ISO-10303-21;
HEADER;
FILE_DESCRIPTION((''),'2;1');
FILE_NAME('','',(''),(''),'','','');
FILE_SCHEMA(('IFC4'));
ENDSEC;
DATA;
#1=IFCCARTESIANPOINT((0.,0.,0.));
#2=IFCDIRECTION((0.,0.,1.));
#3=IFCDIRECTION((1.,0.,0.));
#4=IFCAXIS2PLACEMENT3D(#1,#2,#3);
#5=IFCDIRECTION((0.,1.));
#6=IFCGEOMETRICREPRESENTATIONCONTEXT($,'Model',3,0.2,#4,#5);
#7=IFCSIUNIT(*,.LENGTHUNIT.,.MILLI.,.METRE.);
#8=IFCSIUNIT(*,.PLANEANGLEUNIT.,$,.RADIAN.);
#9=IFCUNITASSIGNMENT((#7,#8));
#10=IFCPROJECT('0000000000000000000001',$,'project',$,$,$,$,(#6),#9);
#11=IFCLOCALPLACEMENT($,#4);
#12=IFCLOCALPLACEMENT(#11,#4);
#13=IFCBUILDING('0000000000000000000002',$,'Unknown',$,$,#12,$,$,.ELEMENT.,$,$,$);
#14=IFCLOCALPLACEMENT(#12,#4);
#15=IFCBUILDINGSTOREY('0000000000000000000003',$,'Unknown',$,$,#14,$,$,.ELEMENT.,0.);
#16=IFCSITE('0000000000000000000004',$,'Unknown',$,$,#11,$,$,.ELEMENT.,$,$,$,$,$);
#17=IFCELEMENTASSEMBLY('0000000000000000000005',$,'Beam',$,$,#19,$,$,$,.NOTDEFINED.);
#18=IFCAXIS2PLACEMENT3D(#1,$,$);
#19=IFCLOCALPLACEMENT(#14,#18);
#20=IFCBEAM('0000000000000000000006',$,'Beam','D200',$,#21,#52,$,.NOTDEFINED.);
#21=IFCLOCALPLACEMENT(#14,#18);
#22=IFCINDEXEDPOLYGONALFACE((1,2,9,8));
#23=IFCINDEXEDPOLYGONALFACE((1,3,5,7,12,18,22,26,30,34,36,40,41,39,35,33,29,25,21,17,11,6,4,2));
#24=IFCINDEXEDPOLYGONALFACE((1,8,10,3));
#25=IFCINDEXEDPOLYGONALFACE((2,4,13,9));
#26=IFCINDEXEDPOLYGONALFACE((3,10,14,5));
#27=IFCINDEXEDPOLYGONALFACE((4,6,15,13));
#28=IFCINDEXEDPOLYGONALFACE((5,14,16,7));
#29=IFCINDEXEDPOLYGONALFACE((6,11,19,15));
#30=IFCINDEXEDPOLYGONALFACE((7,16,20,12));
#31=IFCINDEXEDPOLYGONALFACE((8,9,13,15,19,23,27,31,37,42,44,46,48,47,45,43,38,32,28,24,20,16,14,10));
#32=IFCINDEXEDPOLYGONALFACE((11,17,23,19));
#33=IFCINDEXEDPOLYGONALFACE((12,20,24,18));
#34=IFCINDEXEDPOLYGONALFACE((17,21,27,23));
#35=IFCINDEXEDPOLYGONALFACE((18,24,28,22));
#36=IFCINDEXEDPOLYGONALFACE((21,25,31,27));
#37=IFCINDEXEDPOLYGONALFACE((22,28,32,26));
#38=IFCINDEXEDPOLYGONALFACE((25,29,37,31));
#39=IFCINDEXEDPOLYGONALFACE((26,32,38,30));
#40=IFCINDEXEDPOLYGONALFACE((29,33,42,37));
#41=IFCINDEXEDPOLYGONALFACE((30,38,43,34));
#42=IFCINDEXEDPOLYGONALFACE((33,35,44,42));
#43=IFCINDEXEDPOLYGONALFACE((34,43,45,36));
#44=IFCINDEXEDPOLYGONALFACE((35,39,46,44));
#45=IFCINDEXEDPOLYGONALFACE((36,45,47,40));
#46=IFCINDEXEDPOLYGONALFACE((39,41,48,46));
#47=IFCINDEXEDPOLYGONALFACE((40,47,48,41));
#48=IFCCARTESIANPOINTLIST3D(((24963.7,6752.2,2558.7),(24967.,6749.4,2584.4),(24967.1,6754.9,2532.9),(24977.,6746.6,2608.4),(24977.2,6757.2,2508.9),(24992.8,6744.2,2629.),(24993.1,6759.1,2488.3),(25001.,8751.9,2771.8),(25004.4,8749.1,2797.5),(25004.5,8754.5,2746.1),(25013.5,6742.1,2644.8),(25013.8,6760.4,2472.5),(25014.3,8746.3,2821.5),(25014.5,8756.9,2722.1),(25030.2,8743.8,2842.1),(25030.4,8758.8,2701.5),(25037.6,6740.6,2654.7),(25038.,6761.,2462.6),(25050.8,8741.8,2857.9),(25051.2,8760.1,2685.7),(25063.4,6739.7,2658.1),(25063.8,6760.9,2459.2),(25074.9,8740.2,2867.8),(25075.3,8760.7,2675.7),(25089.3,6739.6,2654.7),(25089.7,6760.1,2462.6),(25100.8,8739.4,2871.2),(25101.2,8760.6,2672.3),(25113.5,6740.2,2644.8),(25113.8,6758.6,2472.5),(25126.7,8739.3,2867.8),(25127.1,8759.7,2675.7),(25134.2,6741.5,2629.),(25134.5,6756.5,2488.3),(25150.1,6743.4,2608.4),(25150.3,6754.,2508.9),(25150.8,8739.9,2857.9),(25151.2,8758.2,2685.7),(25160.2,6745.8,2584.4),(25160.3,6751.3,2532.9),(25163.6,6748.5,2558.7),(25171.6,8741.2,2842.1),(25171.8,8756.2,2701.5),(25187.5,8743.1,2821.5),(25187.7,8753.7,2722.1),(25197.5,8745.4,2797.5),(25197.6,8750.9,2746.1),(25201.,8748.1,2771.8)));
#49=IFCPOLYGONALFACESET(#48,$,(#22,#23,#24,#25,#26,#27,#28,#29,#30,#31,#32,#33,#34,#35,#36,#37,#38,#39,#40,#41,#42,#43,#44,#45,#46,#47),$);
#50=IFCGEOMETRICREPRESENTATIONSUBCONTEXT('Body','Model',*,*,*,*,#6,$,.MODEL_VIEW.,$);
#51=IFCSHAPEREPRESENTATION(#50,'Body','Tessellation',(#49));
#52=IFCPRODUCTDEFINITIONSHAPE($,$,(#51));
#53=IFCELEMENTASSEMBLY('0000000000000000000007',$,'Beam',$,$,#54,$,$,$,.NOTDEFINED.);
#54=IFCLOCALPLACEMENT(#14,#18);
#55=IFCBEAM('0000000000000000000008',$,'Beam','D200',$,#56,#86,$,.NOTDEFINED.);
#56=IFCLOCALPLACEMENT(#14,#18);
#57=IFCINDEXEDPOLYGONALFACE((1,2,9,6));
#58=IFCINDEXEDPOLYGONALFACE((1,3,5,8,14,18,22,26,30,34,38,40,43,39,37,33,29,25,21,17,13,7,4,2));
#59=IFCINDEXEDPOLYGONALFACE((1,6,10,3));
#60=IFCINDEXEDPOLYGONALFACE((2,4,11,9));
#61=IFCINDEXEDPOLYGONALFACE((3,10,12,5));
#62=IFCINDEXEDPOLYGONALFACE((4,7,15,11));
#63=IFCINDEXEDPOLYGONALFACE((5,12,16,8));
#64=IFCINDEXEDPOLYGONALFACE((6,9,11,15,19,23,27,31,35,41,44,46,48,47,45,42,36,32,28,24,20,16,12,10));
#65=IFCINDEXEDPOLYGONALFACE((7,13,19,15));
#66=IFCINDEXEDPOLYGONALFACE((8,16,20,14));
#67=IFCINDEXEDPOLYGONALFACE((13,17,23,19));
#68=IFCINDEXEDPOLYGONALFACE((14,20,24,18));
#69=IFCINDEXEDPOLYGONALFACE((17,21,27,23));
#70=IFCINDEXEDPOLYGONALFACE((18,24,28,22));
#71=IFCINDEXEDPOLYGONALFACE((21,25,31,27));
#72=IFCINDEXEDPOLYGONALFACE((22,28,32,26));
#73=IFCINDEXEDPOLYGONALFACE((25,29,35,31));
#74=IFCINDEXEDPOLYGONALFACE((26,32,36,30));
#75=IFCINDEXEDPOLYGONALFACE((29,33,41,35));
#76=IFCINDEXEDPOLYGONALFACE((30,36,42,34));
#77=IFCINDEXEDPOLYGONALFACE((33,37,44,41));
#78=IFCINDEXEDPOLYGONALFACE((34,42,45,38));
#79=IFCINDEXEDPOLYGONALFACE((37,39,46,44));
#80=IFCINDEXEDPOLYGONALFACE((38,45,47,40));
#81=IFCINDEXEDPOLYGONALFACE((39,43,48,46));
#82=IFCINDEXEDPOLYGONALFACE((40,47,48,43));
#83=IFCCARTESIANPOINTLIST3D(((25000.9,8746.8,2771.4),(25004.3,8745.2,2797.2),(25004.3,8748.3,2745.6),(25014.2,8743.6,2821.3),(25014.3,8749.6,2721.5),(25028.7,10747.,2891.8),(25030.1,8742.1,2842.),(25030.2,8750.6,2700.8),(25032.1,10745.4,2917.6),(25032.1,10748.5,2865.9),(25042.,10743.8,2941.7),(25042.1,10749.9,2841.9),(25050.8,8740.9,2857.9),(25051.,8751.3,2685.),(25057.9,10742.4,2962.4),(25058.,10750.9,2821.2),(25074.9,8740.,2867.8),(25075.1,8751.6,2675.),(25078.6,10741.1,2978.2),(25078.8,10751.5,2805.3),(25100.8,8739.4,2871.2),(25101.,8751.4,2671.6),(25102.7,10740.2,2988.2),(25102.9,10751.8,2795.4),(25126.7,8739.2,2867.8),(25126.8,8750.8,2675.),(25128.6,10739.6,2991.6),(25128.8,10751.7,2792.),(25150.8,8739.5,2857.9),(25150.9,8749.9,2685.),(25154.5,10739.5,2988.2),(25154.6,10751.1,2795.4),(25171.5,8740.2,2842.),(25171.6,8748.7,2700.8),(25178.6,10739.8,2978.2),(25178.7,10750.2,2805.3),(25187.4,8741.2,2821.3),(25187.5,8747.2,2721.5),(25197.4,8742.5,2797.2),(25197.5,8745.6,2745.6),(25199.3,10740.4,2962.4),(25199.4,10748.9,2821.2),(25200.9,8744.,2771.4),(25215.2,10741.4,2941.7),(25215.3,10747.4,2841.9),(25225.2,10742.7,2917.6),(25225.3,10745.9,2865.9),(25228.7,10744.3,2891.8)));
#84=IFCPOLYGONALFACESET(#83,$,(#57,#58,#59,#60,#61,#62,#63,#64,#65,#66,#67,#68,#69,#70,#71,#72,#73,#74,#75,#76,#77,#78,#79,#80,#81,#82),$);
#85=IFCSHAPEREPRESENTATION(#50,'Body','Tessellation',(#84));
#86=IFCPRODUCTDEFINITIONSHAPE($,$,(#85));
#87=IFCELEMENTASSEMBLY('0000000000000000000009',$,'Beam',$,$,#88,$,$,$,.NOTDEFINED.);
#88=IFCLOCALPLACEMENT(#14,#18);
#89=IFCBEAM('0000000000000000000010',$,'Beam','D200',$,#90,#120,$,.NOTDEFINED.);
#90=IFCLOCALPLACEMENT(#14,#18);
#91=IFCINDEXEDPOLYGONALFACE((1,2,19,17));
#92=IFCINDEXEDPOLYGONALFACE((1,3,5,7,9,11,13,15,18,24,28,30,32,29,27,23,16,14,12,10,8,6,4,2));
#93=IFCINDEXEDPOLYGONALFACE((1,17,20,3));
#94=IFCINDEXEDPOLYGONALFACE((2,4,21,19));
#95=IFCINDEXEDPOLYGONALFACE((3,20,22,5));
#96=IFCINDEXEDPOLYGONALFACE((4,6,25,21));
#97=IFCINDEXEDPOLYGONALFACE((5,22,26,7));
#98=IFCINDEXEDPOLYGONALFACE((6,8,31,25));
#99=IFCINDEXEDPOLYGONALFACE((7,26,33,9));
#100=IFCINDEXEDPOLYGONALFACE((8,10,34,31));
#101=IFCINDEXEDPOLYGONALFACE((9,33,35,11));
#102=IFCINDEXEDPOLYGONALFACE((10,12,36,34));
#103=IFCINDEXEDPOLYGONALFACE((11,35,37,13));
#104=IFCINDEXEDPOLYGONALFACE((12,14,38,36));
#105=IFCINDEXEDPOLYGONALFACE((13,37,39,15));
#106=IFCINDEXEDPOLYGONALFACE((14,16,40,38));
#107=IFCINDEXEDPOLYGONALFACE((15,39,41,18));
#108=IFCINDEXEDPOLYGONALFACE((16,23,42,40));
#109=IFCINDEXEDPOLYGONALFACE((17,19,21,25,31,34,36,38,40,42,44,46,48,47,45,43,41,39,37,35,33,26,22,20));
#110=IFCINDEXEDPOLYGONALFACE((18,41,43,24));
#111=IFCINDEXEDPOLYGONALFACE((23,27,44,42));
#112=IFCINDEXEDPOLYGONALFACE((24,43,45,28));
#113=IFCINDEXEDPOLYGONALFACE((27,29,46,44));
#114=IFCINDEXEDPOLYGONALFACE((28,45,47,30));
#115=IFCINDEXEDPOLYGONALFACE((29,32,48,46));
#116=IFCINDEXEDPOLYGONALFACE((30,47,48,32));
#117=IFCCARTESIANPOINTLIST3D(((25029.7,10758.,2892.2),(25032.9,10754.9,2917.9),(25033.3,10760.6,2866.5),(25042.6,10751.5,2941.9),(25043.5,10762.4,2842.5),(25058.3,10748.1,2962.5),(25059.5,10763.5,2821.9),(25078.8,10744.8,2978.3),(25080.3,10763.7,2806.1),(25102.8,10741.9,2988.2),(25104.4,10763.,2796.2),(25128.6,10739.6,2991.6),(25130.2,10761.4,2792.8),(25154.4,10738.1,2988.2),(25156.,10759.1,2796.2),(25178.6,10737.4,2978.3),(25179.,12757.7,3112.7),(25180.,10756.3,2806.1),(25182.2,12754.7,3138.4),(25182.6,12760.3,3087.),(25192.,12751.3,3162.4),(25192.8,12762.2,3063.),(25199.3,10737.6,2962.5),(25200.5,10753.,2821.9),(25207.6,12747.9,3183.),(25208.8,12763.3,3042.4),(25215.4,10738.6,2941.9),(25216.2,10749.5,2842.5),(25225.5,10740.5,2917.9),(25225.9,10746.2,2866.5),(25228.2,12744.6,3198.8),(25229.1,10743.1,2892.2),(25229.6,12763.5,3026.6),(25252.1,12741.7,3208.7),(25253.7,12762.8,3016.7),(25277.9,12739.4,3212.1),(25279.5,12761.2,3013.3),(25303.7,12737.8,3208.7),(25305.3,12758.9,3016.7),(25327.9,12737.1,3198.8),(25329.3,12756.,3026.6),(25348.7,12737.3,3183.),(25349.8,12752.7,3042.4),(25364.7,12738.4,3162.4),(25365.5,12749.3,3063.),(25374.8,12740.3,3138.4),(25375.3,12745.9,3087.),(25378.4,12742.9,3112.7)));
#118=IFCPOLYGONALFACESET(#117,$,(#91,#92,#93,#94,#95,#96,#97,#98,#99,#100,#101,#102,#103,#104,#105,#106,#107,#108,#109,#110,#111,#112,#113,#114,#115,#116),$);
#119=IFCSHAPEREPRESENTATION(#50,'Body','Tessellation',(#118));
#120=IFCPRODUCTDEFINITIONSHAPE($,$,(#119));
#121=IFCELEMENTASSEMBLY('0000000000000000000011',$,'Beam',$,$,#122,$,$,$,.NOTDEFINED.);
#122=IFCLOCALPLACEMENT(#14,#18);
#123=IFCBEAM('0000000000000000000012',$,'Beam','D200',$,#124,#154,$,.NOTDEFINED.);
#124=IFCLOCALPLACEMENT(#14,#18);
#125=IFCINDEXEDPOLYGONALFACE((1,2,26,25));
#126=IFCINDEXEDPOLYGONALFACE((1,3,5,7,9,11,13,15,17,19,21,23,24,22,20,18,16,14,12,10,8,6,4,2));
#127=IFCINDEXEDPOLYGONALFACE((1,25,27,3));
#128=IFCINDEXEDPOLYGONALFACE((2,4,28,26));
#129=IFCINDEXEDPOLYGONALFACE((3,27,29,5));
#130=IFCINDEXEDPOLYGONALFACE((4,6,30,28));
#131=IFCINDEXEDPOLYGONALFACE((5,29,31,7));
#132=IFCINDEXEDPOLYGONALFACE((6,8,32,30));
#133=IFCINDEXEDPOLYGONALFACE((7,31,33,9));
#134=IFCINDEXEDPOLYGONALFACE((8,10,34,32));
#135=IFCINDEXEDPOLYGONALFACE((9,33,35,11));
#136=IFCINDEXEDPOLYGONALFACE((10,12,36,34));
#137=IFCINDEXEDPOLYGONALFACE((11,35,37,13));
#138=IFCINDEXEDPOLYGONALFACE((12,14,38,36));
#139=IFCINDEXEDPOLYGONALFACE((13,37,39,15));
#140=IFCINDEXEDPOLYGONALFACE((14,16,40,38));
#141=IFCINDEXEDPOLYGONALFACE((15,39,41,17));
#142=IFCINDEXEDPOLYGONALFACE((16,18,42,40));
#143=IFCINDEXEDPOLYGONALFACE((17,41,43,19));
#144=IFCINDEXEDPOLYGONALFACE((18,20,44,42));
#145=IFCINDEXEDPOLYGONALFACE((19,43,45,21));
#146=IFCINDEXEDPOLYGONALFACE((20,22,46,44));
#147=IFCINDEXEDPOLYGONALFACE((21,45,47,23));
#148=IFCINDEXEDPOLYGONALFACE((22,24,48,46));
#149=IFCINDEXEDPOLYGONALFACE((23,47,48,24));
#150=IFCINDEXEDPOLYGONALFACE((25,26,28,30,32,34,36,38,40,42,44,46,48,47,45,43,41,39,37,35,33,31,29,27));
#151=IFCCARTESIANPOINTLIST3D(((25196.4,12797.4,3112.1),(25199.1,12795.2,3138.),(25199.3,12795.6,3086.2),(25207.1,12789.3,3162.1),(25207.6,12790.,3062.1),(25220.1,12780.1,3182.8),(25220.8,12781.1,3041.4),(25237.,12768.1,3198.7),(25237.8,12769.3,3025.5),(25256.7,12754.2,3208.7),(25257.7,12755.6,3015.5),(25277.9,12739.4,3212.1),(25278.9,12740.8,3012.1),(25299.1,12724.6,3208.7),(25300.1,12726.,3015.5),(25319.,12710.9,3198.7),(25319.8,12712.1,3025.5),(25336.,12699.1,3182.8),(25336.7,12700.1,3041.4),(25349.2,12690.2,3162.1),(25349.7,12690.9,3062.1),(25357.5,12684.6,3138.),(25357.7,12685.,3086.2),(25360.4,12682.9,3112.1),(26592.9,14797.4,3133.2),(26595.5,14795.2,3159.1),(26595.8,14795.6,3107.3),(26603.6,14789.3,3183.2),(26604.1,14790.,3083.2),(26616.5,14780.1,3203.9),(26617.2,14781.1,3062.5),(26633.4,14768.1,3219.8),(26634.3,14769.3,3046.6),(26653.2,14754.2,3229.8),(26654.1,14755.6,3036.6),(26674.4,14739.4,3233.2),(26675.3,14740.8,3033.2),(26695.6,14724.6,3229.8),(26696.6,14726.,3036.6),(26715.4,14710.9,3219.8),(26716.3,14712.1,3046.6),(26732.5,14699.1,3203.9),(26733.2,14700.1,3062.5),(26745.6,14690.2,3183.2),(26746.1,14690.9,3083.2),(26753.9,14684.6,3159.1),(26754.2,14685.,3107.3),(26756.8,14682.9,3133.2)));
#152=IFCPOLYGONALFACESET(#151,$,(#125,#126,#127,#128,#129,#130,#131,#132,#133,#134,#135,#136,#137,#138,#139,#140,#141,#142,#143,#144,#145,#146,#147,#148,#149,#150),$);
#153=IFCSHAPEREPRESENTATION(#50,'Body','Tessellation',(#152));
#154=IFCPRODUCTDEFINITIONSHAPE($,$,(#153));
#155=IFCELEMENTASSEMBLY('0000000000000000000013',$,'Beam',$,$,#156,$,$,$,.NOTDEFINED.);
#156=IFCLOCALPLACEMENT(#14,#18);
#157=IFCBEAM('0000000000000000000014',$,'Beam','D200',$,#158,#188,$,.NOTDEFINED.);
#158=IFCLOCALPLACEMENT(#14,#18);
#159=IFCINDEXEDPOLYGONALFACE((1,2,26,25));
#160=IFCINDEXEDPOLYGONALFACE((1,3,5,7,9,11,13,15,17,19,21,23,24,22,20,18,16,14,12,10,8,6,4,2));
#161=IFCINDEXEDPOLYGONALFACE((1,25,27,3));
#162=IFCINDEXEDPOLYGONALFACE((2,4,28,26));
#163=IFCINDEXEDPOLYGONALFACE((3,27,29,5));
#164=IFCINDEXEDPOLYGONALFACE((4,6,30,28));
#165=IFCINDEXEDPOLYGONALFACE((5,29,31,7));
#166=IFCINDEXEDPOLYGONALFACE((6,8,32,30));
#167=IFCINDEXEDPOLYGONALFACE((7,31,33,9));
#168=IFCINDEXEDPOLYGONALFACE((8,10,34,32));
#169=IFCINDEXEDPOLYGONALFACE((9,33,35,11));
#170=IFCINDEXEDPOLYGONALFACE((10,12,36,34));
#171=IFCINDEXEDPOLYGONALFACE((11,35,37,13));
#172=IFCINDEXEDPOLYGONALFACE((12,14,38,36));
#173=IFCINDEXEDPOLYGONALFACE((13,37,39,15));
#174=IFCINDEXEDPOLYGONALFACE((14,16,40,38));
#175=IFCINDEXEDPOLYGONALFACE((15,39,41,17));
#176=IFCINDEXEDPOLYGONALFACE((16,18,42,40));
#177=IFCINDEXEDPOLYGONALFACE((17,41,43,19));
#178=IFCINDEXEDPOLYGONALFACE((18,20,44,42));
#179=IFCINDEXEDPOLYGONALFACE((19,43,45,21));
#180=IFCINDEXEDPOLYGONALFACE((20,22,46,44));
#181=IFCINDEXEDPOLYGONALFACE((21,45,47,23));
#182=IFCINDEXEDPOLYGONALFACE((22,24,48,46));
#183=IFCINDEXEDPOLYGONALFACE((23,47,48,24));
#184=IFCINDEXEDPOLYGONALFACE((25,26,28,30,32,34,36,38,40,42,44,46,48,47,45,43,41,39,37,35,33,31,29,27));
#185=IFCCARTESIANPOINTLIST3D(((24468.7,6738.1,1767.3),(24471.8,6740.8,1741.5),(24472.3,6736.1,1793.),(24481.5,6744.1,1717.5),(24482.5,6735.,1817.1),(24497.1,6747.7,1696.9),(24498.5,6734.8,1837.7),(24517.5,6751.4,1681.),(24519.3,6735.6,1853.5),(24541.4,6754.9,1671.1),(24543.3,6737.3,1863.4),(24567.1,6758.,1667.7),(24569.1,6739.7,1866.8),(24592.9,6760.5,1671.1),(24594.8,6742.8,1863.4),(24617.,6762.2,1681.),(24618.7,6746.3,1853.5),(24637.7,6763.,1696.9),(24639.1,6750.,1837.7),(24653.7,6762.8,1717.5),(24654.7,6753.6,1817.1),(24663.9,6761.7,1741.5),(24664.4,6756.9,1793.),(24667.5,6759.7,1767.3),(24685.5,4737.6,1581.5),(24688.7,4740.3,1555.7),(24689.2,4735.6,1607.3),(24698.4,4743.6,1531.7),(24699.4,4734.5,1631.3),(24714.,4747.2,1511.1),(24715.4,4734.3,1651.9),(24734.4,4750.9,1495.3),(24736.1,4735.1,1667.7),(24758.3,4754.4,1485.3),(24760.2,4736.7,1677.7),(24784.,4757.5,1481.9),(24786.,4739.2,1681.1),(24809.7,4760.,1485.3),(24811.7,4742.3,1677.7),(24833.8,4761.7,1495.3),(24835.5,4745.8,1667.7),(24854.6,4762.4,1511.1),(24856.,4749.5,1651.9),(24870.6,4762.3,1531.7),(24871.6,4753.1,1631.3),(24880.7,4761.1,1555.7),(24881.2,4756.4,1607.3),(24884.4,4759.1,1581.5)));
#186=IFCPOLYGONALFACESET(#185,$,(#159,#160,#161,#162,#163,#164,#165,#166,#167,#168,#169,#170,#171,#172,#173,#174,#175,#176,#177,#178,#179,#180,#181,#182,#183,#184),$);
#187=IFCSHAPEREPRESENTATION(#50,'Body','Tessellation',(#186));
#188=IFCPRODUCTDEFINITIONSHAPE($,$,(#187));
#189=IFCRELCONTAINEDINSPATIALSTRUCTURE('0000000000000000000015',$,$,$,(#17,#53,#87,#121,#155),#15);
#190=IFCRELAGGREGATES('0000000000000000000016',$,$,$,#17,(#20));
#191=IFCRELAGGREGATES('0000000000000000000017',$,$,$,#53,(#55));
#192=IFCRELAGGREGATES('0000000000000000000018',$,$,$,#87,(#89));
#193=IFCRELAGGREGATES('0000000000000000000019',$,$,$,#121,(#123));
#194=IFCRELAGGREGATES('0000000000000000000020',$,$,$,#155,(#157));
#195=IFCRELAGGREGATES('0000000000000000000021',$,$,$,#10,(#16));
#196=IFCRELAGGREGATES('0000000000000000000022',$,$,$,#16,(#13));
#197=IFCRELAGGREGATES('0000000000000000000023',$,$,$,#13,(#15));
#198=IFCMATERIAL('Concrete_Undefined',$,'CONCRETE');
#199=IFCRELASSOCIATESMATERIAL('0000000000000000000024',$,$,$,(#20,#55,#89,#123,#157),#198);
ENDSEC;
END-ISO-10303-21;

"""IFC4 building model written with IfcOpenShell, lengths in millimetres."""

from ifc_helpers import new_model, si_unit, direction, frame, origin_with_axes, place, context, subcontext, project, spatial, line, indexed_curve, outline, extrude, material, element, aggregate, save


model = new_model("IFC4")

# Units and contexts
model_context = context("Model", 3, precision=0.2, world=origin_with_axes(), true_north=direction((0.0, 1.0)))
body_context = subcontext(model_context, "Body", "Model", "MODEL_VIEW")
ifc_project = project(units=[si_unit("LENGTHUNIT", "METRE", prefix="MILLI"), si_unit("PLANEANGLEUNIT", "RADIAN")], contexts=[model_context])

# Site, building, storey
site_placement = place(None, origin_with_axes())
site = spatial("IfcSite", under=ifc_project, at=site_placement, Name="Unknown", CompositionType="ELEMENT")
building_placement = place(site_placement, origin_with_axes())
building = spatial("IfcBuilding", under=site, at=building_placement, Name="Unknown", CompositionType="ELEMENT")
storey_placement = place(building_placement, origin_with_axes())
storey = spatial("IfcBuildingStorey", under=building, at=storey_placement, Name="Unknown", CompositionType="ELEMENT", Elevation=0.0)

# Shared definitions
ifc_material = material(Name="Concrete_Undefined", Category="CONCRETE")

# Element assemblies, beams
assembly_1_placement = place(storey_placement, frame((25101.0, 8750.0, 2771.8), z_axis=(-0.999826, 0.018677, 0.0), x_axis=(-0.018572, -0.994196, -0.105966)))
assembly_1 = element("IfcElementAssembly", 1, at=assembly_1_placement, inside=storey, Name="Beam", PredefinedType="NOTDEFINED")
beam_1_placement = place(assembly_1_placement, origin_with_axes())
beam_1 = element("IfcBeam", 2, at=beam_1_placement, material=ifc_material, Name="Beam", Description="D200", PredefinedType="NOTDEFINED", context=body_context, shape_type="SolidModel", body=[
    extrude(outline(indexed_curve([(100.0, 0.0), (96.6, 25.9), (86.6, 50.0), (70.7, 70.7), (50.0, 86.6), (25.9, 96.6), (0.0, 100.0), (-25.9, 96.6), (-50.0, 86.6), (-70.7, 70.7), (-86.6, 50.0), (-96.6, 25.9), (-100.0, 0.0), (-96.6, -25.9), (-86.6, -50.0), (-70.7, -70.7), (-50.0, -86.6), (-25.9, -96.6), (0.0, -100.0), (25.9, -96.6), (50.0, -86.6), (70.7, -70.7), (86.6, -50.0), (96.6, -25.9)], segments=[line(1, 2, 3, 4, 5, 6, 7, 8, 9, 10, 11, 12, 13, 14, 15, 16, 17, 18, 19, 20, 21, 22, 23, 24, 1)])), frame((0.0, 0.0, 0.0), z_axis=(-1.0, 0.0, 0.0), x_axis=(0.0, 0.0, 1.0)), (0.0, 0.0, -1.0), 2011.3),
])
aggregate(assembly_1, [beam_1])
assembly_2_placement = place(storey_placement, frame((25128.7, 10745.6, 2891.8), z_axis=(-0.999903, 0.013896, 0.0), x_axis=(-0.013871, -0.998098, -0.060066)))
assembly_2 = element("IfcElementAssembly", 3, at=assembly_2_placement, inside=storey, Name="Beam", PredefinedType="NOTDEFINED")
beam_2_placement = place(assembly_2_placement, origin_with_axes())
beam_2 = element("IfcBeam", 4, at=beam_2_placement, material=ifc_material, Name="Beam", Description="D200", PredefinedType="NOTDEFINED", context=body_context, shape_type="SolidModel", body=[
    extrude(outline(indexed_curve([(100.0, 0.0), (96.6, 25.9), (86.6, 50.0), (70.7, 70.7), (50.0, 86.6), (25.9, 96.6), (0.0, 100.0), (-25.9, 96.6), (-50.0, 86.6), (-70.7, 70.7), (-86.6, 50.0), (-96.6, 25.9), (-100.0, 0.0), (-96.6, -25.9), (-86.6, -50.0), (-70.7, -70.7), (-50.0, -86.6), (-25.9, -96.6), (0.0, -100.0), (25.9, -96.6), (50.0, -86.6), (70.7, -70.7), (86.6, -50.0), (96.6, -25.9)], segments=[line(1, 2, 3, 4, 5, 6, 7, 8, 9, 10, 11, 12, 13, 14, 15, 16, 17, 18, 19, 20, 21, 22, 23, 24, 1)])), frame((0.0, 0.0, 0.0), z_axis=(-1.0, 0.0, 0.0), x_axis=(0.0, 0.0, 1.0)), (0.0, 0.0, -1.0), 2004.1),
])
aggregate(assembly_2, [beam_2])
assembly_3_placement = place(storey_placement, frame((25278.7, 12750.3, 3112.7), z_axis=(-0.997224, 0.074458, 0.0), x_axis=(-0.074012, -0.99125, -0.1093)))
assembly_3 = element("IfcElementAssembly", 5, at=assembly_3_placement, inside=storey, Name="Beam", PredefinedType="NOTDEFINED")
beam_3_placement = place(assembly_3_placement, origin_with_axes())
beam_3 = element("IfcBeam", 6, at=beam_3_placement, material=ifc_material, Name="Beam", Description="D200", PredefinedType="NOTDEFINED", context=body_context, shape_type="SolidModel", body=[
    extrude(outline(indexed_curve([(100.0, 0.0), (96.6, 25.9), (86.6, 50.0), (70.7, 70.7), (50.0, 86.6), (25.9, 96.6), (0.0, 100.0), (-25.9, 96.6), (-50.0, 86.6), (-70.7, 70.7), (-86.6, 50.0), (-96.6, 25.9), (-100.0, 0.0), (-96.6, -25.9), (-86.6, -50.0), (-70.7, -70.7), (-50.0, -86.6), (-25.9, -96.6), (0.0, -100.0), (25.9, -96.6), (50.0, -86.6), (70.7, -70.7), (86.6, -50.0), (96.6, -25.9)], segments=[line(1, 2, 3, 4, 5, 6, 7, 8, 9, 10, 11, 12, 13, 14, 15, 16, 17, 18, 19, 20, 21, 22, 23, 24, 1)])), frame((0.0, 0.0, 0.0), z_axis=(-1.0, 0.0, 0.0), x_axis=(0.0, 0.0, 1.0)), (0.0, 0.0, -1.0), 2017.4),
])
aggregate(assembly_3, [beam_3])
assembly_4_placement = place(storey_placement, frame((26674.9, 14740.1, 3133.2), z_axis=(-0.819915, 0.572485, 0.0), x_axis=(-0.572463, -0.819885, -0.008641)))
assembly_4 = element("IfcElementAssembly", 7, at=assembly_4_placement, inside=storey, Name="Beam", PredefinedType="NOTDEFINED")
beam_4_placement = place(assembly_4_placement, origin_with_axes())
beam_4 = element("IfcBeam", 8, at=beam_4_placement, material=ifc_material, Name="Beam", Description="D200", PredefinedType="NOTDEFINED", context=body_context, shape_type="SolidModel", body=[
    extrude(outline(indexed_curve([(100.0, 0.0), (96.6, 25.9), (86.6, 50.0), (70.7, 70.7), (50.0, 86.6), (25.9, 96.6), (0.0, 100.0), (-25.9, 96.6), (-50.0, 86.6), (-70.7, 70.7), (-86.6, 50.0), (-96.6, 25.9), (-100.0, 0.0), (-96.6, -25.9), (-86.6, -50.0), (-70.7, -70.7), (-50.0, -86.6), (-25.9, -96.6), (0.0, -100.0), (25.9, -96.6), (50.0, -86.6), (70.7, -70.7), (86.6, -50.0), (96.6, -25.9)], segments=[line(1, 2, 3, 4, 5, 6, 7, 8, 9, 10, 11, 12, 13, 14, 15, 16, 17, 18, 19, 20, 21, 22, 23, 24, 1)])), frame((0.0, 0.0, 0.0), z_axis=(-1.0, 0.0, 0.0), x_axis=(0.0, 0.0, 1.0)), (0.0, 0.0, -1.0), 2439.4),
])
aggregate(assembly_4, [beam_4])
assembly_5_placement = place(storey_placement, frame((24568.1, 6748.9, 1767.3), z_axis=(-0.994176, -0.107768, 0.0), x_axis=(0.107311, -0.989966, -0.091932)))
assembly_5 = element("IfcElementAssembly", 9, at=assembly_5_placement, inside=storey, Name="Beam", PredefinedType="NOTDEFINED")
beam_5_placement = place(assembly_5_placement, origin_with_axes())
beam_5 = element("IfcBeam", 10, at=beam_5_placement, material=ifc_material, Name="Beam", Description="D200", PredefinedType="NOTDEFINED", context=body_context, shape_type="SolidModel", body=[
    extrude(outline(indexed_curve([(100.0, 0.0), (96.6, 25.9), (86.6, 50.0), (70.7, 70.7), (50.0, 86.6), (25.9, 96.6), (0.0, 100.0), (-25.9, 96.6), (-50.0, 86.6), (-70.7, 70.7), (-86.6, 50.0), (-96.6, 25.9), (-100.0, 0.0), (-96.6, -25.9), (-86.6, -50.0), (-70.7, -70.7), (-50.0, -86.6), (-25.9, -96.6), (0.0, -100.0), (25.9, -96.6), (50.0, -86.6), (70.7, -70.7), (86.6, -50.0), (96.6, -25.9)], segments=[line(1, 2, 3, 4, 5, 6, 7, 8, 9, 10, 11, 12, 13, 14, 15, 16, 17, 18, 19, 20, 21, 22, 23, 24, 1)])), frame((0.0, 0.0, 0.0), z_axis=(-1.0, 0.0, 0.0), x_axis=(0.0, 0.0, 1.0)), (0.0, 0.0, -1.0), 2020.8),
])
aggregate(assembly_5, [beam_5])

save(model, "model.ifc")
